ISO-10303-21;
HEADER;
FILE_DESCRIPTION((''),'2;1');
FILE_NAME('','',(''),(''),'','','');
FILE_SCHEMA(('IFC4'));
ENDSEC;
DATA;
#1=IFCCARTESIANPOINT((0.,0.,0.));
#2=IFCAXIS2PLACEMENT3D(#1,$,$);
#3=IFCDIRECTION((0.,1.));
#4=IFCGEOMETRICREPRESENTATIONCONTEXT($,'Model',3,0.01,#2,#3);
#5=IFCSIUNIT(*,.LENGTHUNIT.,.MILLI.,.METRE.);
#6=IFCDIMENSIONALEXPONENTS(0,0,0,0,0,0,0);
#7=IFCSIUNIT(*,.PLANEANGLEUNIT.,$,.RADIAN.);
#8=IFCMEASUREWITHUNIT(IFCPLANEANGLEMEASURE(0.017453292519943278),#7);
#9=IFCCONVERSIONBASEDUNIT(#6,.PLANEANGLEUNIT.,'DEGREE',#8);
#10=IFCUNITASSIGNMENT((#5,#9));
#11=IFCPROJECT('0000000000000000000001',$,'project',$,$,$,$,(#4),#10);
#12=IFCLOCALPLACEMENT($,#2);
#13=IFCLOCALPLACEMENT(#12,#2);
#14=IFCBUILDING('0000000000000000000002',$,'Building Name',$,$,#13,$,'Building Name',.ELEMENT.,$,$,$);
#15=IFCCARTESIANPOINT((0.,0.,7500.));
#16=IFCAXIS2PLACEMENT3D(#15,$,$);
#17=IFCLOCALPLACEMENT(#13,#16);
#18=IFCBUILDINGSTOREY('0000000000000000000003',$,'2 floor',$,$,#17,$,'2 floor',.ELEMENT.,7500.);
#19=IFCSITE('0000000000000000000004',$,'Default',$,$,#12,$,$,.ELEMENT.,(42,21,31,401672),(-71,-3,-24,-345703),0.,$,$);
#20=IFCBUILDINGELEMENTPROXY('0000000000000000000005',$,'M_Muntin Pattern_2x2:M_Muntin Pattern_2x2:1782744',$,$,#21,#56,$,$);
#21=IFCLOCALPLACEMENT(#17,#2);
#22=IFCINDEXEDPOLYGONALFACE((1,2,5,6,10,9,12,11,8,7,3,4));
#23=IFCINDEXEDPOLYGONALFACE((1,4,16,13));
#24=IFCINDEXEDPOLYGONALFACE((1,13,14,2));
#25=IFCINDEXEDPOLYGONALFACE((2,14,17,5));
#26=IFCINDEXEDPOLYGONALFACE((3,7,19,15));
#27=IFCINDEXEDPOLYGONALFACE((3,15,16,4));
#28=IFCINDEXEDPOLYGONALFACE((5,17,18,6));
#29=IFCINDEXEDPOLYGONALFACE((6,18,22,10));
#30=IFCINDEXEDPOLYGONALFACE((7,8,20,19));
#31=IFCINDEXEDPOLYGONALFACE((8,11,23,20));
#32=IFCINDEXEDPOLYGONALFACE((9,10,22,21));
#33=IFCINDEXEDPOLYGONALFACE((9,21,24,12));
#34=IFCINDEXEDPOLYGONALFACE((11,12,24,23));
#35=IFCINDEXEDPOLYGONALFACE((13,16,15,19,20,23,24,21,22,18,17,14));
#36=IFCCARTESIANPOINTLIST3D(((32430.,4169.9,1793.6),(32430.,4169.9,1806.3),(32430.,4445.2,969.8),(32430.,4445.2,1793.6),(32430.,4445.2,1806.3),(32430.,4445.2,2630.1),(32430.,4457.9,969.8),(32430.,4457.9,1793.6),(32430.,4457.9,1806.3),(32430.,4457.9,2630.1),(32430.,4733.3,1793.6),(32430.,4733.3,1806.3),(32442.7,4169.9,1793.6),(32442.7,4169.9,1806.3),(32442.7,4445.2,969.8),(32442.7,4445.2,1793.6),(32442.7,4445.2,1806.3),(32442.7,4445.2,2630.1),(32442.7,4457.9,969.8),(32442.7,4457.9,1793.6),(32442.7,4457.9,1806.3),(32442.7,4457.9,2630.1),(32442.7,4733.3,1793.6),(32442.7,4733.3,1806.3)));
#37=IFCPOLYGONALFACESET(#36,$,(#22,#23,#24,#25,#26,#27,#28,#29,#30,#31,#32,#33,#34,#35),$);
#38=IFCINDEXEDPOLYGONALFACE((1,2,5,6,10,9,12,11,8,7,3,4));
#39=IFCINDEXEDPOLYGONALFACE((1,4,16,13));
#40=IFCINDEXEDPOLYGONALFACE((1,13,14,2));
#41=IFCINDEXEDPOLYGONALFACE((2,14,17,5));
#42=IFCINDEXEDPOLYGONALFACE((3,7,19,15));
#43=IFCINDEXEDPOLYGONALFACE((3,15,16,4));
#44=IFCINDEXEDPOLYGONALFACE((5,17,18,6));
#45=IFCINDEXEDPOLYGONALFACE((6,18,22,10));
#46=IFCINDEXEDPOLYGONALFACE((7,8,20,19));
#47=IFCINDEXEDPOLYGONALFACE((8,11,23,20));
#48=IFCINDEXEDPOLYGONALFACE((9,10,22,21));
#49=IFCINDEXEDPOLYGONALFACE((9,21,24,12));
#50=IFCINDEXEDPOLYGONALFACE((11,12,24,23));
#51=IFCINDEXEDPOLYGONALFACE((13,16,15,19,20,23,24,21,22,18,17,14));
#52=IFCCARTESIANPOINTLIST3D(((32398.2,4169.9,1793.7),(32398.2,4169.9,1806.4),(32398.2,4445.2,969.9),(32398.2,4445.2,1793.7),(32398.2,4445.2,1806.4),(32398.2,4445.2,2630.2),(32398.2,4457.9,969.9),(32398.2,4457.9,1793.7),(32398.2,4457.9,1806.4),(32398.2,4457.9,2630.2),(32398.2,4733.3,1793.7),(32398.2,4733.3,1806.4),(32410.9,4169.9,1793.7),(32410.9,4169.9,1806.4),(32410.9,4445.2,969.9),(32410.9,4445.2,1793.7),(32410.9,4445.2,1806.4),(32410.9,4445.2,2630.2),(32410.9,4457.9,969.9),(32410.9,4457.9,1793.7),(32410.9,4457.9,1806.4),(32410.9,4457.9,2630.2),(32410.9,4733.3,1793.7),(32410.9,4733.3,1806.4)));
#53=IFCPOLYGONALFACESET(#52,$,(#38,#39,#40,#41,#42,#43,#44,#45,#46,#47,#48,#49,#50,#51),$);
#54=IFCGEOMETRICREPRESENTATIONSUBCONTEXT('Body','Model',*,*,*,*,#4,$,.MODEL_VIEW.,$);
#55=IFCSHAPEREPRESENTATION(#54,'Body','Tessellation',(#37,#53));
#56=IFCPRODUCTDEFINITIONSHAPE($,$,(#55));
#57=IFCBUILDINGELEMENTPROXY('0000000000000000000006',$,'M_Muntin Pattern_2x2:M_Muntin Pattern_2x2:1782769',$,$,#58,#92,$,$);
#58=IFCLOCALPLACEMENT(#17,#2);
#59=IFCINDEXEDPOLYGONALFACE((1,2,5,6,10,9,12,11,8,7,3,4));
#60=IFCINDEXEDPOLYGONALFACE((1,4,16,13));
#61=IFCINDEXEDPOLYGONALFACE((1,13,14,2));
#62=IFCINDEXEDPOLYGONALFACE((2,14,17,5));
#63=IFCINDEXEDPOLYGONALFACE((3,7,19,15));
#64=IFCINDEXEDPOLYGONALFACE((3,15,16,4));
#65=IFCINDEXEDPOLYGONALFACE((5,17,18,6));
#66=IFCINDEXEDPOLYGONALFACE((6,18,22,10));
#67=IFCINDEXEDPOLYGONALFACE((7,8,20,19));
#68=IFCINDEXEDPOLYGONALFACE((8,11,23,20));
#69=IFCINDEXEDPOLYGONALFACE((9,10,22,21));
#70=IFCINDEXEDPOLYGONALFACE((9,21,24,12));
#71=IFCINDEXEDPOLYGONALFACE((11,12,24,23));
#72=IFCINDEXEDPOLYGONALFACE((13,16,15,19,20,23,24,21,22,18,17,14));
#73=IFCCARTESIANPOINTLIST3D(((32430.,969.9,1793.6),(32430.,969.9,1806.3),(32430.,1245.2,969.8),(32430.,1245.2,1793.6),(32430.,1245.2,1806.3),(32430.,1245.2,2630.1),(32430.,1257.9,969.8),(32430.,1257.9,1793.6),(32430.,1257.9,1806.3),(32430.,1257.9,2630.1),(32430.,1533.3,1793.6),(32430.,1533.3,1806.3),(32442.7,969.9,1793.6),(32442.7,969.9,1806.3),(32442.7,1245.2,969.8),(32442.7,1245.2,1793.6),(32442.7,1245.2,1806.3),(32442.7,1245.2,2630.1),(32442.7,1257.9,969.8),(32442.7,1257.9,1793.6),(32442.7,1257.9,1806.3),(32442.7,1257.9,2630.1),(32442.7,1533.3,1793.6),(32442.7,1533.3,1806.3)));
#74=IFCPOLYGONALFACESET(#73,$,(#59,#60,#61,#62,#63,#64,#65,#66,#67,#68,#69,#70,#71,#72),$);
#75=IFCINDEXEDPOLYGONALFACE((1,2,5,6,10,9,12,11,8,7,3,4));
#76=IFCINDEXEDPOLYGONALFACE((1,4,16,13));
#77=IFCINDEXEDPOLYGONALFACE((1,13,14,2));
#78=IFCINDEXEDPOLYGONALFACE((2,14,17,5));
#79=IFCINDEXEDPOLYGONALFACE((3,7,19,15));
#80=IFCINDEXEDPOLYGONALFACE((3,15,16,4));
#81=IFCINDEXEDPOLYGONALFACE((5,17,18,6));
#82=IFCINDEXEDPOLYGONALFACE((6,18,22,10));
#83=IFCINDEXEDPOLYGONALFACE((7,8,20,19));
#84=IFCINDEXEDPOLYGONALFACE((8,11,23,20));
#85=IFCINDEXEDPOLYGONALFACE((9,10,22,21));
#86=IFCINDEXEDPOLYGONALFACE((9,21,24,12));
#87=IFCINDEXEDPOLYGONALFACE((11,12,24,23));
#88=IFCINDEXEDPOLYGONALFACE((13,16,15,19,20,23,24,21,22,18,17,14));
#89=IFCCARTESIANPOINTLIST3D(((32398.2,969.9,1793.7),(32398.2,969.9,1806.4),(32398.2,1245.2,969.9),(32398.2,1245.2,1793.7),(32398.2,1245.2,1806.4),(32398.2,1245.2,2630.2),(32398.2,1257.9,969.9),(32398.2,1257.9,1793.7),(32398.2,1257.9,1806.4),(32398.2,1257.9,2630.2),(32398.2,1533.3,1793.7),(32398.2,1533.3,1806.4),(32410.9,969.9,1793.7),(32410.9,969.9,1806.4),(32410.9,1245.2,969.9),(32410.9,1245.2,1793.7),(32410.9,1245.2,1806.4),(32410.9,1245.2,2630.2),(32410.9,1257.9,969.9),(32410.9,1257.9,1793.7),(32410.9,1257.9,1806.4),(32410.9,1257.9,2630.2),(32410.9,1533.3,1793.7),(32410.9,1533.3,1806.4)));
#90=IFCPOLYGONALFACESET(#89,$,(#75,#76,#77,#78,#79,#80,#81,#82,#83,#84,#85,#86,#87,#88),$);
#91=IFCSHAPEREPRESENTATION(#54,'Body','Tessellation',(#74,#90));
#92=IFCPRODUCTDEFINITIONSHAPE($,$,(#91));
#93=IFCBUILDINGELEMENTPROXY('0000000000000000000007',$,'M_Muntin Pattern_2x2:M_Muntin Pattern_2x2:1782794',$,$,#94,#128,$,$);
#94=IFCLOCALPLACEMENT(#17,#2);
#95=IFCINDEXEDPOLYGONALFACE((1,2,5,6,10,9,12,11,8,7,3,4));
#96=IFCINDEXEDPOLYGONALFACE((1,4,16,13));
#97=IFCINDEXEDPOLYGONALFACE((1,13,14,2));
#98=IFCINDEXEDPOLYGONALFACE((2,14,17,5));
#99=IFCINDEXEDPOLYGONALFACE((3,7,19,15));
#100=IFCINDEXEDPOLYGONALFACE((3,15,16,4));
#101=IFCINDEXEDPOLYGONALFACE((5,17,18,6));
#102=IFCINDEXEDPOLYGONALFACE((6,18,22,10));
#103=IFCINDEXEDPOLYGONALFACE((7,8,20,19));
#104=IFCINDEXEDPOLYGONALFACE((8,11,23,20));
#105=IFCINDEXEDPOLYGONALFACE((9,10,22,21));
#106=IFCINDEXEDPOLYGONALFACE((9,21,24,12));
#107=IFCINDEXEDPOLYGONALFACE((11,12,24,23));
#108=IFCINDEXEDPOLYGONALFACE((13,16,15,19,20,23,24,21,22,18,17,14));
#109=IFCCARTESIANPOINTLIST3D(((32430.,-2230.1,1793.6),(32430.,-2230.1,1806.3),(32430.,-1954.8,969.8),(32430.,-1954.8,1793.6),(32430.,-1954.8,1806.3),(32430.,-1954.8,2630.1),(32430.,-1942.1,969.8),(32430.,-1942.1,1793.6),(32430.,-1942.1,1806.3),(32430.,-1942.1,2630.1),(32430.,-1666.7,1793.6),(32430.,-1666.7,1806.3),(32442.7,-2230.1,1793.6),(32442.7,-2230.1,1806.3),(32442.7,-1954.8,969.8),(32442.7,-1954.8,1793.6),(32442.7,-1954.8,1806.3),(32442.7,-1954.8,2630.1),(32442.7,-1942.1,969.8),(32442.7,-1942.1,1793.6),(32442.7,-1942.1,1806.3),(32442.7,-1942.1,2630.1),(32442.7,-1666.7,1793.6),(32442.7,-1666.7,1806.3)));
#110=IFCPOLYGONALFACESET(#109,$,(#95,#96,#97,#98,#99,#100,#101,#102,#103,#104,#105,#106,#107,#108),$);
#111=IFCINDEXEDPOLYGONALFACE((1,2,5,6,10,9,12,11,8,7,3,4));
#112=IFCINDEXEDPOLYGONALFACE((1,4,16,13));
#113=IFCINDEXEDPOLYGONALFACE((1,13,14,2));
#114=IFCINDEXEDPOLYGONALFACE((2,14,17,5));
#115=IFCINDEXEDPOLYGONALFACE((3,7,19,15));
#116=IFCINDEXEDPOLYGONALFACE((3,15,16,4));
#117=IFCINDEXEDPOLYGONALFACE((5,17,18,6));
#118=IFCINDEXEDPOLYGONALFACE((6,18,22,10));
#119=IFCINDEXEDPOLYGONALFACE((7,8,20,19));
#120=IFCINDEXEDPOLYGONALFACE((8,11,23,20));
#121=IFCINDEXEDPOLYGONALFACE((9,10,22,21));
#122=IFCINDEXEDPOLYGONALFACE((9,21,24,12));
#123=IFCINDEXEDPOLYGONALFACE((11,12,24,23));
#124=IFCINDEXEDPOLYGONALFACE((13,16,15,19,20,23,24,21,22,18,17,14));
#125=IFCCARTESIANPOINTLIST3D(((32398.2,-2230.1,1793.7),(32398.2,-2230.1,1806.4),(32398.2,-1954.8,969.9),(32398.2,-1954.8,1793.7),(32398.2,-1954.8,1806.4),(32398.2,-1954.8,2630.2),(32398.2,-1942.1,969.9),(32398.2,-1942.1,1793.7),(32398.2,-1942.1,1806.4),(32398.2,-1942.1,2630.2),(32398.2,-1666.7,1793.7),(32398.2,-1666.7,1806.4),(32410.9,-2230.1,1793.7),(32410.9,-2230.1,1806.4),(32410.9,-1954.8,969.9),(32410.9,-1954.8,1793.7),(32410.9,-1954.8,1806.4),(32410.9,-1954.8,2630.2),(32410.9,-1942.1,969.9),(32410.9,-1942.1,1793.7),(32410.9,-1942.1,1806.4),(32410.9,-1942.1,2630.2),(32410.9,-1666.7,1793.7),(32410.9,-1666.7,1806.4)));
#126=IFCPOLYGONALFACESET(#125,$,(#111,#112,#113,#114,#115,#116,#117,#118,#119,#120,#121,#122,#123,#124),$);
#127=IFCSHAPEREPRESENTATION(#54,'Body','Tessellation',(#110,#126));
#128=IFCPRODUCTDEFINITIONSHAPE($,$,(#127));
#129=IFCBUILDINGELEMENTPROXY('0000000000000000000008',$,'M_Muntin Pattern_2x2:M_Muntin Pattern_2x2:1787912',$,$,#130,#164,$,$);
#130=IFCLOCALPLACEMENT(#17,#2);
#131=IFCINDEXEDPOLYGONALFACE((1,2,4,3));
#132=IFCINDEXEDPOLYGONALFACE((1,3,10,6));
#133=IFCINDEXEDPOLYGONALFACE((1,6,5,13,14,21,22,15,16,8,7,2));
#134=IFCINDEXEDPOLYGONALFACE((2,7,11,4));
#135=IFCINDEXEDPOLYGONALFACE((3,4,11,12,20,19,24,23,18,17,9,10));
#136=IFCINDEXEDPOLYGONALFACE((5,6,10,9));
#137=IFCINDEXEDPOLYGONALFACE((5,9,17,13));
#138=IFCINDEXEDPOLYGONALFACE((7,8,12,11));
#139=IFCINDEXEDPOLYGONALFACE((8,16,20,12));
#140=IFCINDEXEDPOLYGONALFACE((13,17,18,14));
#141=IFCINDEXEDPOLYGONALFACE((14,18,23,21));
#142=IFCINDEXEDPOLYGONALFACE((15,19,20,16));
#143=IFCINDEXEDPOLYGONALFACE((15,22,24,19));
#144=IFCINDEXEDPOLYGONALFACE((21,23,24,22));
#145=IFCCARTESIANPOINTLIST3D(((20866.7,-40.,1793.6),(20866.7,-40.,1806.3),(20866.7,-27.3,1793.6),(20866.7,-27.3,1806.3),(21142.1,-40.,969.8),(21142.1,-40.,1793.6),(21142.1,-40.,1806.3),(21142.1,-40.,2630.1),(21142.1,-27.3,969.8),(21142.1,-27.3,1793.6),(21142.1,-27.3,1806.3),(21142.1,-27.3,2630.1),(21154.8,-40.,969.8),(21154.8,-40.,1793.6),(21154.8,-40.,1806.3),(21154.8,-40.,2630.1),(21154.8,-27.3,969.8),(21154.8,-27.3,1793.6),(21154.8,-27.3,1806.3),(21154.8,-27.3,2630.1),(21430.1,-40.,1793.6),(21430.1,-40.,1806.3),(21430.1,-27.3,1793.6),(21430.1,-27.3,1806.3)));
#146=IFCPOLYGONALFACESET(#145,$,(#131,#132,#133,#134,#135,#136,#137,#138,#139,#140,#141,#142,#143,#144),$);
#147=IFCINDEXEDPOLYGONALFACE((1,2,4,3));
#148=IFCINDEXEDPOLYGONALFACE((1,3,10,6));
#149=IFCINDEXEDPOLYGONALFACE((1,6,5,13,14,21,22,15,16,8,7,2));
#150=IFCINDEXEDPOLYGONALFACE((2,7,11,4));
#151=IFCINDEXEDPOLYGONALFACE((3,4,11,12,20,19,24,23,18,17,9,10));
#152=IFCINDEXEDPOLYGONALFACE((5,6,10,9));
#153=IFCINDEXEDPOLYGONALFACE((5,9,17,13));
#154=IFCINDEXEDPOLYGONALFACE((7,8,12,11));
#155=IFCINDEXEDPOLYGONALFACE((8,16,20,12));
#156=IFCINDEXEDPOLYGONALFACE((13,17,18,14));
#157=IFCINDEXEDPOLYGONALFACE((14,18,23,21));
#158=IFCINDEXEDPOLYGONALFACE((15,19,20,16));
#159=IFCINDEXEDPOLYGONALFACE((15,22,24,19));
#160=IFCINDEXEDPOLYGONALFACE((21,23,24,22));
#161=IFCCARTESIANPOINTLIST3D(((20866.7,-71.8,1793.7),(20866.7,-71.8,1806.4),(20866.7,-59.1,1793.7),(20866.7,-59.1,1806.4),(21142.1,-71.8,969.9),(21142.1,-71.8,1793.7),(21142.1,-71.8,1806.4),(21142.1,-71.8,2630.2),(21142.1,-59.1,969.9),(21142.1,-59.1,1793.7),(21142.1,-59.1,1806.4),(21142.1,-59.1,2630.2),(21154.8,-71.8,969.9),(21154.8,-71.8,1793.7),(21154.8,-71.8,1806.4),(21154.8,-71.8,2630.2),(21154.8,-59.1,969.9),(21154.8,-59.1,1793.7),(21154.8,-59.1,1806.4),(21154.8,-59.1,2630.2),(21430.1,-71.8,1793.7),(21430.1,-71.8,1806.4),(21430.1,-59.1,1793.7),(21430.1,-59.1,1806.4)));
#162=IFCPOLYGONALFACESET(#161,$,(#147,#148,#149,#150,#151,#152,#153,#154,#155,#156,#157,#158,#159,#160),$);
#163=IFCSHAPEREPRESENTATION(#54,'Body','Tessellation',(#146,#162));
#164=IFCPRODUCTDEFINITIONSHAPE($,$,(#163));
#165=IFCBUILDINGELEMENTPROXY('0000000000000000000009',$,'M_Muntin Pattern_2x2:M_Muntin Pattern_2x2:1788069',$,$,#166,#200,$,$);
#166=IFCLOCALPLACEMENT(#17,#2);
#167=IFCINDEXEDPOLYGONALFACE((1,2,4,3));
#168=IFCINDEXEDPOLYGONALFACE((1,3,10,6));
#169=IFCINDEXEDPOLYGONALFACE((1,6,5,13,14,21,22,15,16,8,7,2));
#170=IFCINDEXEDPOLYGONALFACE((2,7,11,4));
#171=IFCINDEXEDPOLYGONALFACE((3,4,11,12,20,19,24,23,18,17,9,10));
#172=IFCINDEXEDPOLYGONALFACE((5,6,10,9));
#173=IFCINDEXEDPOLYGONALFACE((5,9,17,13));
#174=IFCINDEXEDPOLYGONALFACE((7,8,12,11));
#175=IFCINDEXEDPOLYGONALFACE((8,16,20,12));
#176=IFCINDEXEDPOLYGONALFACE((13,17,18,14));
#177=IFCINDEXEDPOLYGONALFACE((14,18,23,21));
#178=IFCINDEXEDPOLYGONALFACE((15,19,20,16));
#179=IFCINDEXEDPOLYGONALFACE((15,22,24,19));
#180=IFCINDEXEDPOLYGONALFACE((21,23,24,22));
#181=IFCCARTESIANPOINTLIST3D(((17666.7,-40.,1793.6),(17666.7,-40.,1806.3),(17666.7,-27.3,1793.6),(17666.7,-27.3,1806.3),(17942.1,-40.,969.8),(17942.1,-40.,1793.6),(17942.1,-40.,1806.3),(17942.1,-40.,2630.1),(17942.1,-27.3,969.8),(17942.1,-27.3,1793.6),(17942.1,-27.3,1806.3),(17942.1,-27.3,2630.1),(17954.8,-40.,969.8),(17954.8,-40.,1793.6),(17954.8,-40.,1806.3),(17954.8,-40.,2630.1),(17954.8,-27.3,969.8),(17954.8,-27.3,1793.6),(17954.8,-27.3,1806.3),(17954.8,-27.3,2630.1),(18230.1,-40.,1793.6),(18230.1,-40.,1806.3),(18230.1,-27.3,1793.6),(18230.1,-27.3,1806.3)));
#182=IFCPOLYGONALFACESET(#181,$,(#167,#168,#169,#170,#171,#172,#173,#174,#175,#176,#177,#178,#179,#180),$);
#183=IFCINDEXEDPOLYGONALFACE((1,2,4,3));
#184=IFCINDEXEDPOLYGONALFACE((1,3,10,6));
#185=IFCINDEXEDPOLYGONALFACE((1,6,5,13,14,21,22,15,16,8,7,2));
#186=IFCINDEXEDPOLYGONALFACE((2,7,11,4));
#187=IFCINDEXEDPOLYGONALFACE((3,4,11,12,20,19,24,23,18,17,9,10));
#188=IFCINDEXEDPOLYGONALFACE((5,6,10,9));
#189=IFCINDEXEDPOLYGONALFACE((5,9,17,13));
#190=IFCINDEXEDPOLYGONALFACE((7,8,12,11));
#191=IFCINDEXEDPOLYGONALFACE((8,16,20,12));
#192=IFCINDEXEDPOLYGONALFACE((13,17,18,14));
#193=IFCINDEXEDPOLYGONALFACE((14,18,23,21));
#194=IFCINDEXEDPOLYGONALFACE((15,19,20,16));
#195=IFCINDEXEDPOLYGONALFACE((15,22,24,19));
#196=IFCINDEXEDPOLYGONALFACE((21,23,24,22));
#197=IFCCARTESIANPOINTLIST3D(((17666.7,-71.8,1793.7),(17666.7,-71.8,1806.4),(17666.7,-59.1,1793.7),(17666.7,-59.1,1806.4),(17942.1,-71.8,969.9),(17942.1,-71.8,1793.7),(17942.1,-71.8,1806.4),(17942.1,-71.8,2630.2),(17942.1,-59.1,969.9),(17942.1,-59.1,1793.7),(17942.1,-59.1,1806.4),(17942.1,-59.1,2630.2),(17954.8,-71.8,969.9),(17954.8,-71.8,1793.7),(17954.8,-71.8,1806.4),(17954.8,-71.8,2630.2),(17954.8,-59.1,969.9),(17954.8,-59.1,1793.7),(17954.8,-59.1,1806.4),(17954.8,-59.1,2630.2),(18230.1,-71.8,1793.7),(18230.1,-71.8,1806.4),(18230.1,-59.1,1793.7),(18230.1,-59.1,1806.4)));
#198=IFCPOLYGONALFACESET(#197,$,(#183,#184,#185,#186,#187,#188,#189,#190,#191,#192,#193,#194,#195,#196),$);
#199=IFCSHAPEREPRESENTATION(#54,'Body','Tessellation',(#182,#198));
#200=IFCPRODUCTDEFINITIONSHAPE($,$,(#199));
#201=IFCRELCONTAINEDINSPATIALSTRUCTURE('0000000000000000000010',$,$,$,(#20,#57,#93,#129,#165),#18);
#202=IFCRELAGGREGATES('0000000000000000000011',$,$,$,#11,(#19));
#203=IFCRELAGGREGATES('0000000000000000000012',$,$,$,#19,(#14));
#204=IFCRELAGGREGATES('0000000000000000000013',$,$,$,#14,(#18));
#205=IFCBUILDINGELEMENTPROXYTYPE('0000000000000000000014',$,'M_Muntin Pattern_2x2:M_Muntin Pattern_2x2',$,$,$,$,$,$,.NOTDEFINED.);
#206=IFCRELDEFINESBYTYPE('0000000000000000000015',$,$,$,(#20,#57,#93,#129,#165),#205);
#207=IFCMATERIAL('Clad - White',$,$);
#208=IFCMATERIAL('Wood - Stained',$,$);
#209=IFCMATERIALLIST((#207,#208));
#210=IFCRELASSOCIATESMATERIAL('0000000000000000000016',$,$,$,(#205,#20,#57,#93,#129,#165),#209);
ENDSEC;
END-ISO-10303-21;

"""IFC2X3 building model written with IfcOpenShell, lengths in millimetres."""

from ifc_helpers import new_model, entity, si_unit, converted_unit, direction, frame, origin, place, context, subcontext, project, spatial, polyline, outline, extrude, source, transform, mapped, material, material_list, type_object, type_shapes, element, save


model = new_model("IFC2X3")

# Units and contexts
model_context = context("Model", 3, precision=0.01, world=origin(), true_north=direction((0.0, 1.0)))
body_context = subcontext(model_context, "Body", "Model", "MODEL_VIEW")
ifc_project = project(units=[si_unit("LENGTHUNIT", "METRE", prefix="MILLI"), converted_unit("PLANEANGLEUNIT", "DEGREE", entity("IfcPlaneAngleMeasure", 0.017453292519943278), si_unit("PLANEANGLEUNIT", "RADIAN"), dimensions=[0, 0, 0, 0, 0, 0, 0])], contexts=[model_context])

# Site, building, storey
site_placement = place(None, origin())
site = spatial("IfcSite", under=ifc_project, at=site_placement, Name="Default", CompositionType="ELEMENT", RefLatitude=(42, 21, 31, 401672), RefLongitude=(-71, -3, -24, -345703), RefElevation=0.0)
building_placement = place(site_placement, origin())
building = spatial("IfcBuilding", under=site, at=building_placement, Name="Building Name", LongName="Building Name", CompositionType="ELEMENT")
storey_placement = place(building_placement, frame((0.0, 0.0, 7500.0)))
storey = spatial("IfcBuildingStorey", under=building, at=storey_placement, Name="2 floor", LongName="2 floor", CompositionType="ELEMENT", Elevation=7500.0)

# Building element proxies
ifc_material_1 = material(Name="Clad - White")
ifc_material_2 = material(Name="Wood - Stained")
ifc_material_list = material_list([ifc_material_1, ifc_material_2])
building_element_proxy_type_1 = type_object("IfcBuildingElementProxyType", Name="M_Muntin Pattern_2x2:M_Muntin Pattern_2x2", PredefinedType="NOTDEFINED", material=ifc_material_list)
shared_shape_1 = source(origin(), body_context, "Body", "SweptSolid", [
    extrude(outline(polyline([(6.4, -6.4), (830.1, -6.4), (830.1, 6.3), (6.4, 6.3), (6.4, 281.7), (-6.3, 281.7), (-6.3, 6.3), (-830.2, 6.3), (-830.2, -6.4), (-6.3, -6.4), (-6.3, -281.7), (6.4, -281.7), (6.4, -6.4)])), frame((0.0, -22.2, 830.1), z_axis=(0.0, 1.0, 0.0), x_axis=(0.0, 0.0, 1.0)), (0.0, 0.0, 1.0), 12.7),
    extrude(outline(polyline([(6.4, -6.4), (830.2, -6.4), (830.2, 6.3), (6.4, 6.3), (6.4, 281.7), (-6.3, 281.7), (-6.3, 6.3), (-830.2, 6.3), (-830.2, -6.4), (-6.3, -6.4), (-6.3, -281.7), (6.4, -281.7), (6.4, -6.4)])), frame((0.0, 9.5, 830.2), z_axis=(0.0, 1.0, 0.0), x_axis=(0.0, 0.0, 1.0)), (0.0, 0.0, 1.0), 12.7),
])
type_shapes(building_element_proxy_type_1, [shared_shape_1])
for number, where, z_axis, x_axis, name in (
    (1, (32420.5, 4451.6, 969.9), (0.0, 0.0, 1.0), (0.0, 1.0, 0.0), "M_Muntin Pattern_2x2:M_Muntin Pattern_2x2:1782744"),
    (2, (32420.5, 1251.6, 969.9), (0.0, 0.0, 1.0), (0.0, 1.0, 0.0), "M_Muntin Pattern_2x2:M_Muntin Pattern_2x2:1782769"),
    (3, (32420.5, -1948.4, 969.9), (0.0, 0.0, 1.0), (0.0, 1.0, 0.0), "M_Muntin Pattern_2x2:M_Muntin Pattern_2x2:1782794"),
    (4, (21148.4, -49.5, 969.9), (0.0, 0.0, 1.0), (-1.0, 0.0, 0.0), "M_Muntin Pattern_2x2:M_Muntin Pattern_2x2:1787912"),
    (5, (17948.4, -49.5, 969.9), (0.0, 0.0, 1.0), (-1.0, 0.0, 0.0), "M_Muntin Pattern_2x2:M_Muntin Pattern_2x2:1788069"),
):
    element("IfcBuildingElementProxy", number, at=place(storey_placement, frame(where, z_axis=z_axis, x_axis=x_axis)), inside=storey, type_object=building_element_proxy_type_1, material=ifc_material_list, Name=name, context=body_context, shape_type="MappedRepresentation", body=[
        mapped(shared_shape_1, transform((0.0, 0.0, 0.0), scale=1.0)),
    ])

save(model, "model.ifc")
